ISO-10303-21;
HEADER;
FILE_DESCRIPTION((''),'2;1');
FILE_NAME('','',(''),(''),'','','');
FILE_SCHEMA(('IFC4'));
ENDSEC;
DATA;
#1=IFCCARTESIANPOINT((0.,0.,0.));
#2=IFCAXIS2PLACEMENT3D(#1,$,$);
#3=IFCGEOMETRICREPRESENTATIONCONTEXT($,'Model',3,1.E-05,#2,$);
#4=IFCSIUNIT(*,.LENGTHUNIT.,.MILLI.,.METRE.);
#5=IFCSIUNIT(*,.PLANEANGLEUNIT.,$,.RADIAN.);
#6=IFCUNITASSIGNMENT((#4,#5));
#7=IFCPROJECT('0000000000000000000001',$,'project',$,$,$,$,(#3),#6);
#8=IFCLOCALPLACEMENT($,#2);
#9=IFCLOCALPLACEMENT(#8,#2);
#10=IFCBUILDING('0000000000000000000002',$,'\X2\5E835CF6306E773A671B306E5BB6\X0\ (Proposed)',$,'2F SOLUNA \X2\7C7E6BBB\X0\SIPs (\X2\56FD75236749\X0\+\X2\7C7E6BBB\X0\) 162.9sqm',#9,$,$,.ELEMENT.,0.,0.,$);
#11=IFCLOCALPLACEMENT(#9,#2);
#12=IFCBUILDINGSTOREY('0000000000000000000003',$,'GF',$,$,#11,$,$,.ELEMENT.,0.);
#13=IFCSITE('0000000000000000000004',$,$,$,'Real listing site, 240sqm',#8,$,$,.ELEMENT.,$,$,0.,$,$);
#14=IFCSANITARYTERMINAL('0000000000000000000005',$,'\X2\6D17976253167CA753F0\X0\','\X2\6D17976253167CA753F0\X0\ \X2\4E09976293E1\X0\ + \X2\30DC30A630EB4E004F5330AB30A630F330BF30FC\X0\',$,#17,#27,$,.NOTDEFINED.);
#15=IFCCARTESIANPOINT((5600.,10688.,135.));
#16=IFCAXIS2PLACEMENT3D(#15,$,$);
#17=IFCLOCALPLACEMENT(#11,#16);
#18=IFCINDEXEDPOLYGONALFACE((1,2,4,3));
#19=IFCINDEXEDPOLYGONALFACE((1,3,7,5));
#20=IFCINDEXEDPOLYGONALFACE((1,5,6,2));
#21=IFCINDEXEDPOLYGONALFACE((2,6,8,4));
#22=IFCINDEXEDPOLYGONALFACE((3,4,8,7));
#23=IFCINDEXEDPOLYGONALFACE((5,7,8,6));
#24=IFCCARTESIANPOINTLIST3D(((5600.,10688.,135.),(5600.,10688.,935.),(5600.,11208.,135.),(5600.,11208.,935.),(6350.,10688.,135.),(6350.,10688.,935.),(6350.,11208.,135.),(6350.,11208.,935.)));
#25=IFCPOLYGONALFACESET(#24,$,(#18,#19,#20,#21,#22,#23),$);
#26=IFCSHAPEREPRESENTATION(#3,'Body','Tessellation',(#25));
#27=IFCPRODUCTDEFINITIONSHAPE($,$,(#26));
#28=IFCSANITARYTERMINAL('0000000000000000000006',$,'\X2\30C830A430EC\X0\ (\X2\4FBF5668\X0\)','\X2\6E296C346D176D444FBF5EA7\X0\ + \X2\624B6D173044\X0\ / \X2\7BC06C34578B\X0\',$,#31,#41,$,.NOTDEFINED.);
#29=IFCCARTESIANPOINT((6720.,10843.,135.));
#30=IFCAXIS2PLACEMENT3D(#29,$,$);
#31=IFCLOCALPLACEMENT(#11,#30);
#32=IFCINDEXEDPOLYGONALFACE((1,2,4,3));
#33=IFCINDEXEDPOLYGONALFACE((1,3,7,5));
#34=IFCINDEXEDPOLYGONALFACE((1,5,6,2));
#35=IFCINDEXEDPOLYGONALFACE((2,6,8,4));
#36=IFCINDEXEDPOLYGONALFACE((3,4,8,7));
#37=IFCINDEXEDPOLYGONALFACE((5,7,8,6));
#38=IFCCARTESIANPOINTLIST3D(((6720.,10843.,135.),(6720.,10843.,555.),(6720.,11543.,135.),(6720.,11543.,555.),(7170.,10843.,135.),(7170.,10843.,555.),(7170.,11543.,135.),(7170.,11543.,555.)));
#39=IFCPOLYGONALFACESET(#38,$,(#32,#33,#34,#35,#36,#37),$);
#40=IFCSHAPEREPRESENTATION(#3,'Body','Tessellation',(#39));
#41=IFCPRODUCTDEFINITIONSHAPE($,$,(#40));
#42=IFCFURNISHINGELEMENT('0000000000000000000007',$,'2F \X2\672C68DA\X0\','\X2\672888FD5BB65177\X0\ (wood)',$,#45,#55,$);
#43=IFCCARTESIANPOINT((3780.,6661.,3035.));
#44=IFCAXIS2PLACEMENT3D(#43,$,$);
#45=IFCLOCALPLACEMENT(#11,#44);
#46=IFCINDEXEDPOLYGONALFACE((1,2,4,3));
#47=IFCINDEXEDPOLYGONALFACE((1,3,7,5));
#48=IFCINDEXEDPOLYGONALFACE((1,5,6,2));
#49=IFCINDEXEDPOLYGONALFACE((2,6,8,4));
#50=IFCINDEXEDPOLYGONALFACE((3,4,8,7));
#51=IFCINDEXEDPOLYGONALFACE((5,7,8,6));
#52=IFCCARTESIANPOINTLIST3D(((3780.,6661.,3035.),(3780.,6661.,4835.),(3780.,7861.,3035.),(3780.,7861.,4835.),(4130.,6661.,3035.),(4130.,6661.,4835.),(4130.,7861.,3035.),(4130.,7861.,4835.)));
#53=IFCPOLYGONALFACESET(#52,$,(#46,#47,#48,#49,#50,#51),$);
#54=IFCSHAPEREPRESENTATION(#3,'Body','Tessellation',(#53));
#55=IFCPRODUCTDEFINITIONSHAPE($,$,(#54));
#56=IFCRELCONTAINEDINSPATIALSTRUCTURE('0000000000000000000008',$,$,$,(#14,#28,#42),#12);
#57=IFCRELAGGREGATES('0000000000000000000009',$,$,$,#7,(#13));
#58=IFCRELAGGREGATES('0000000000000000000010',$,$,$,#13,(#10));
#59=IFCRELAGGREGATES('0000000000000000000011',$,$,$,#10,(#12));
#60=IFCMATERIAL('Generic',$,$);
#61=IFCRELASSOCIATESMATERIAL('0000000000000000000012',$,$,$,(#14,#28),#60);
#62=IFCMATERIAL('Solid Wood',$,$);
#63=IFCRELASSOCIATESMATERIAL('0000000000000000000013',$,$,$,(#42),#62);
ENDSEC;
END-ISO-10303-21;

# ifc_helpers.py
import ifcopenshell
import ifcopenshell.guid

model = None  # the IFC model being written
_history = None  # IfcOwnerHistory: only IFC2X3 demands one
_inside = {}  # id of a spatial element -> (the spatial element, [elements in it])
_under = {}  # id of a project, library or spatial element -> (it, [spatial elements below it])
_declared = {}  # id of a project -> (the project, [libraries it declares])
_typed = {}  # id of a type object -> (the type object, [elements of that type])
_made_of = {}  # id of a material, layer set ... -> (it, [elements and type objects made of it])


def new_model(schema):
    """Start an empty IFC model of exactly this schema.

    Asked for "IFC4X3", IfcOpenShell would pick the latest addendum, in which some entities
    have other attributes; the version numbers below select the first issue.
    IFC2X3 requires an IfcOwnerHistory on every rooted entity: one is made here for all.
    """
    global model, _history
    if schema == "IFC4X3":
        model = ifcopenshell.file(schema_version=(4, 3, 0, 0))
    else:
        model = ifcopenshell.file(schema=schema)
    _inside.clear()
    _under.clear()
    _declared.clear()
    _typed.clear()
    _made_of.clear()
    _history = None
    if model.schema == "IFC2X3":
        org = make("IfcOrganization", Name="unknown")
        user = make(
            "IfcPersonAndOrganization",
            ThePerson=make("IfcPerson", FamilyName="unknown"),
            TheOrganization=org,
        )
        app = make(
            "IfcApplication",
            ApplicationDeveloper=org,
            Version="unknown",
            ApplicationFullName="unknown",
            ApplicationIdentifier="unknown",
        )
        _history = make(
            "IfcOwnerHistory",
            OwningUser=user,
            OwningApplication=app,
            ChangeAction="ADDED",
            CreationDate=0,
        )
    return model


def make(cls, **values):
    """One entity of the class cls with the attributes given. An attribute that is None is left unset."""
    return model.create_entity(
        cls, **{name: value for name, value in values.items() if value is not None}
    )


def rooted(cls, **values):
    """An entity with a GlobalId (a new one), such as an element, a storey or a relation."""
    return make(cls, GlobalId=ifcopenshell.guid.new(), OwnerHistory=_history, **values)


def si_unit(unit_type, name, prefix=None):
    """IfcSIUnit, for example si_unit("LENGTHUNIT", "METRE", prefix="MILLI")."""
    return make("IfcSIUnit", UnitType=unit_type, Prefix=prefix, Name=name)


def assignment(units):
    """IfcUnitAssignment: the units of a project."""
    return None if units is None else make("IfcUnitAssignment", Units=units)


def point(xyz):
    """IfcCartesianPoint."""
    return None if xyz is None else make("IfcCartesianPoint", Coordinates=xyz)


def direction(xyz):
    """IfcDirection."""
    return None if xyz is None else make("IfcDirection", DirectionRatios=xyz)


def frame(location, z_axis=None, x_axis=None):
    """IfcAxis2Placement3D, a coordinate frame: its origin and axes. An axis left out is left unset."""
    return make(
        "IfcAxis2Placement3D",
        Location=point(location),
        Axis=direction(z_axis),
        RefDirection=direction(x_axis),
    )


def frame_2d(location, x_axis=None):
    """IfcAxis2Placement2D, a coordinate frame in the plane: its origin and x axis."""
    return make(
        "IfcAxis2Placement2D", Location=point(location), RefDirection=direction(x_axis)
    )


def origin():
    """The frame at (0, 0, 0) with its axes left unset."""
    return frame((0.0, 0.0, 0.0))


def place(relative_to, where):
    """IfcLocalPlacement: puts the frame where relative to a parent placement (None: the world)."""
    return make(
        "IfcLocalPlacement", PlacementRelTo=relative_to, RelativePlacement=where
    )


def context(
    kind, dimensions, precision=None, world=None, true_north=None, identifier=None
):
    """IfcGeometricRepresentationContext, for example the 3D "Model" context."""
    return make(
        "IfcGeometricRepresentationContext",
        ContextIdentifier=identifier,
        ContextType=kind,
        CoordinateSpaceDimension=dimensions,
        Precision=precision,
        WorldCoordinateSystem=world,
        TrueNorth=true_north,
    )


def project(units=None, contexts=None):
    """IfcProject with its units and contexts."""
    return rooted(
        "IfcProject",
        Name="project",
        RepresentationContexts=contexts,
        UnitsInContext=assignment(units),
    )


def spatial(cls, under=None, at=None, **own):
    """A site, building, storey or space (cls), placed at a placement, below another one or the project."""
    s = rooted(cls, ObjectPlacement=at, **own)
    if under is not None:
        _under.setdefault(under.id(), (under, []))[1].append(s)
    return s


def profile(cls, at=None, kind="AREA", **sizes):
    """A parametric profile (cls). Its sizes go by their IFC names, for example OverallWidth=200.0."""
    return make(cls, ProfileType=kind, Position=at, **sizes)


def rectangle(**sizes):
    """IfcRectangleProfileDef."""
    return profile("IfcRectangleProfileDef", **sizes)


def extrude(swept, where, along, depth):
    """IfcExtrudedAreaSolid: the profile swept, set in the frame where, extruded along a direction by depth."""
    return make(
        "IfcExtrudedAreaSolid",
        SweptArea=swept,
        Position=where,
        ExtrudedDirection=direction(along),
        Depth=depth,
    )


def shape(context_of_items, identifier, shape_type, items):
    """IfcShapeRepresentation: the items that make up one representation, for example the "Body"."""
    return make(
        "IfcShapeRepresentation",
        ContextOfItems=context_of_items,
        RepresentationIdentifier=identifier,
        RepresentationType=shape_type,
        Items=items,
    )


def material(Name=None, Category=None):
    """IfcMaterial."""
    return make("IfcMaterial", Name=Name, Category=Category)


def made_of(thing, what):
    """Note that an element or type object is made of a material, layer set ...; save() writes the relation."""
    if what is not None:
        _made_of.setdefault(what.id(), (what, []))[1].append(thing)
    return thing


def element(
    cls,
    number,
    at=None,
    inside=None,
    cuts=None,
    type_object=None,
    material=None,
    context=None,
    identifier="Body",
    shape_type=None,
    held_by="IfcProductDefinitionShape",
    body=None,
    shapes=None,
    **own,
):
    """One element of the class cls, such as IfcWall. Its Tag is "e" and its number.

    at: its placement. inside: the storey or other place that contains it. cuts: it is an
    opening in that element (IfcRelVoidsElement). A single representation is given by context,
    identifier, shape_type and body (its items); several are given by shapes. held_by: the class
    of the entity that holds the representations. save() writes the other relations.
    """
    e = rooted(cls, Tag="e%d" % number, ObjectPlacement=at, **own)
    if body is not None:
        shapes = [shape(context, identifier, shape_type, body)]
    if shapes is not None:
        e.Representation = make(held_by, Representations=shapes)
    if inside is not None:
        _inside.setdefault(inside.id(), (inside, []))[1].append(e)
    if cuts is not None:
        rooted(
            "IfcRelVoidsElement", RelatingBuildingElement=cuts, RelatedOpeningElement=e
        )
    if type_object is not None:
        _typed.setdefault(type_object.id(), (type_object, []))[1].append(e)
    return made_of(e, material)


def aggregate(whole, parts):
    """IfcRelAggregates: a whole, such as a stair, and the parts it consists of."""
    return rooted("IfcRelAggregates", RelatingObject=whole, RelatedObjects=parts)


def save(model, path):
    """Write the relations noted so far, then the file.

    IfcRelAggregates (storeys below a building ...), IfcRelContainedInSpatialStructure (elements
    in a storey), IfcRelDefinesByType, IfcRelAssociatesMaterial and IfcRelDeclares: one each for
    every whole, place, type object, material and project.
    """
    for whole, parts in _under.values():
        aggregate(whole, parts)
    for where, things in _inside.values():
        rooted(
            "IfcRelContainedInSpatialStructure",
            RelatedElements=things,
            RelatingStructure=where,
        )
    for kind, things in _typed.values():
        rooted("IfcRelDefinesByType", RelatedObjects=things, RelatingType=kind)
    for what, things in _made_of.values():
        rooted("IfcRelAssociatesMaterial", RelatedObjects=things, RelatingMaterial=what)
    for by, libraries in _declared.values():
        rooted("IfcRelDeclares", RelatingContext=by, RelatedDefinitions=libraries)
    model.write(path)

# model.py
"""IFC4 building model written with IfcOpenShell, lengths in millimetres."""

from ifc_helpers import new_model, si_unit, frame, frame_2d, origin, place, context, project, spatial, rectangle, extrude, material, element, save


model = new_model("IFC4")

# Units and contexts
model_context = context("Model", 3, precision=1e-05, world=origin())
ifc_project = project(units=[si_unit("LENGTHUNIT", "METRE", prefix="MILLI"), si_unit("PLANEANGLEUNIT", "RADIAN")], contexts=[model_context])

# Site, building, storey
site_placement = place(None, origin())
site = spatial("IfcSite", under=ifc_project, at=site_placement, ObjectType="Real listing site, 240sqm", CompositionType="ELEMENT", RefElevation=0.0)
building_placement = place(site_placement, origin())
building = spatial("IfcBuilding", under=site, at=building_placement, Name="広島の眺望の家 (Proposed)", ObjectType="2F SOLUNA 籾殻SIPs (国産杉+籾殻) 162.9sqm", CompositionType="ELEMENT", ElevationOfRefHeight=0.0, ElevationOfTerrain=0.0)
storey_placement = place(building_placement, origin())
storey = spatial("IfcBuildingStorey", under=building, at=storey_placement, Name="GF", CompositionType="ELEMENT", Elevation=0.0)

# Shared definitions
ifc_material_1 = material(Name="Solid Wood")
ifc_material_2 = material(Name="Generic")

# Sanitary terminals
sanitary_terminal_1_placement = place(storey_placement, frame((5600.0, 10688.0, 135.0)))
element("IfcSanitaryTerminal", 1, at=sanitary_terminal_1_placement, inside=storey, material=ifc_material_2, Name="洗面化粧台", Description="洗面化粧台 三面鏡 + ボウル一体カウンター", PredefinedType="NOTDEFINED", context=model_context, shape_type="SweptSolid", body=[
    extrude(rectangle(XDim=750.0, YDim=520.0, at=frame_2d((375.0, 260.0))), frame((5600.0, 10688.0, 135.0)), (0.0, 0.0, 1.0), 800.0),
])
sanitary_terminal_2_placement = place(storey_placement, frame((6720.0, 10843.0, 135.0)))
element("IfcSanitaryTerminal", 2, at=sanitary_terminal_2_placement, inside=storey, material=ifc_material_2, Name="トイレ (便器)", Description="温水洗浄便座 + 手洗い / 節水型", PredefinedType="NOTDEFINED", context=model_context, shape_type="SweptSolid", body=[
    extrude(rectangle(XDim=450.0, YDim=700.0, at=frame_2d((225.0, 350.0))), frame((6720.0, 10843.0, 135.0)), (0.0, 0.0, 1.0), 420.0),
])

# Furnishing element
furnishing_placement = place(storey_placement, frame((3780.0, 6661.0, 3035.0)))
element("IfcFurnishingElement", 3, at=furnishing_placement, inside=storey, material=ifc_material_1, Name="2F 本棚", Description="木製家具 (wood)", context=model_context, shape_type="SweptSolid", body=[
    extrude(rectangle(XDim=350.0, YDim=1200.0, at=frame_2d((175.0, 600.0))), frame((3780.0, 6661.0, 3035.0)), (0.0, 0.0, 1.0), 1800.0),
])

save(model, "model.ifc")
